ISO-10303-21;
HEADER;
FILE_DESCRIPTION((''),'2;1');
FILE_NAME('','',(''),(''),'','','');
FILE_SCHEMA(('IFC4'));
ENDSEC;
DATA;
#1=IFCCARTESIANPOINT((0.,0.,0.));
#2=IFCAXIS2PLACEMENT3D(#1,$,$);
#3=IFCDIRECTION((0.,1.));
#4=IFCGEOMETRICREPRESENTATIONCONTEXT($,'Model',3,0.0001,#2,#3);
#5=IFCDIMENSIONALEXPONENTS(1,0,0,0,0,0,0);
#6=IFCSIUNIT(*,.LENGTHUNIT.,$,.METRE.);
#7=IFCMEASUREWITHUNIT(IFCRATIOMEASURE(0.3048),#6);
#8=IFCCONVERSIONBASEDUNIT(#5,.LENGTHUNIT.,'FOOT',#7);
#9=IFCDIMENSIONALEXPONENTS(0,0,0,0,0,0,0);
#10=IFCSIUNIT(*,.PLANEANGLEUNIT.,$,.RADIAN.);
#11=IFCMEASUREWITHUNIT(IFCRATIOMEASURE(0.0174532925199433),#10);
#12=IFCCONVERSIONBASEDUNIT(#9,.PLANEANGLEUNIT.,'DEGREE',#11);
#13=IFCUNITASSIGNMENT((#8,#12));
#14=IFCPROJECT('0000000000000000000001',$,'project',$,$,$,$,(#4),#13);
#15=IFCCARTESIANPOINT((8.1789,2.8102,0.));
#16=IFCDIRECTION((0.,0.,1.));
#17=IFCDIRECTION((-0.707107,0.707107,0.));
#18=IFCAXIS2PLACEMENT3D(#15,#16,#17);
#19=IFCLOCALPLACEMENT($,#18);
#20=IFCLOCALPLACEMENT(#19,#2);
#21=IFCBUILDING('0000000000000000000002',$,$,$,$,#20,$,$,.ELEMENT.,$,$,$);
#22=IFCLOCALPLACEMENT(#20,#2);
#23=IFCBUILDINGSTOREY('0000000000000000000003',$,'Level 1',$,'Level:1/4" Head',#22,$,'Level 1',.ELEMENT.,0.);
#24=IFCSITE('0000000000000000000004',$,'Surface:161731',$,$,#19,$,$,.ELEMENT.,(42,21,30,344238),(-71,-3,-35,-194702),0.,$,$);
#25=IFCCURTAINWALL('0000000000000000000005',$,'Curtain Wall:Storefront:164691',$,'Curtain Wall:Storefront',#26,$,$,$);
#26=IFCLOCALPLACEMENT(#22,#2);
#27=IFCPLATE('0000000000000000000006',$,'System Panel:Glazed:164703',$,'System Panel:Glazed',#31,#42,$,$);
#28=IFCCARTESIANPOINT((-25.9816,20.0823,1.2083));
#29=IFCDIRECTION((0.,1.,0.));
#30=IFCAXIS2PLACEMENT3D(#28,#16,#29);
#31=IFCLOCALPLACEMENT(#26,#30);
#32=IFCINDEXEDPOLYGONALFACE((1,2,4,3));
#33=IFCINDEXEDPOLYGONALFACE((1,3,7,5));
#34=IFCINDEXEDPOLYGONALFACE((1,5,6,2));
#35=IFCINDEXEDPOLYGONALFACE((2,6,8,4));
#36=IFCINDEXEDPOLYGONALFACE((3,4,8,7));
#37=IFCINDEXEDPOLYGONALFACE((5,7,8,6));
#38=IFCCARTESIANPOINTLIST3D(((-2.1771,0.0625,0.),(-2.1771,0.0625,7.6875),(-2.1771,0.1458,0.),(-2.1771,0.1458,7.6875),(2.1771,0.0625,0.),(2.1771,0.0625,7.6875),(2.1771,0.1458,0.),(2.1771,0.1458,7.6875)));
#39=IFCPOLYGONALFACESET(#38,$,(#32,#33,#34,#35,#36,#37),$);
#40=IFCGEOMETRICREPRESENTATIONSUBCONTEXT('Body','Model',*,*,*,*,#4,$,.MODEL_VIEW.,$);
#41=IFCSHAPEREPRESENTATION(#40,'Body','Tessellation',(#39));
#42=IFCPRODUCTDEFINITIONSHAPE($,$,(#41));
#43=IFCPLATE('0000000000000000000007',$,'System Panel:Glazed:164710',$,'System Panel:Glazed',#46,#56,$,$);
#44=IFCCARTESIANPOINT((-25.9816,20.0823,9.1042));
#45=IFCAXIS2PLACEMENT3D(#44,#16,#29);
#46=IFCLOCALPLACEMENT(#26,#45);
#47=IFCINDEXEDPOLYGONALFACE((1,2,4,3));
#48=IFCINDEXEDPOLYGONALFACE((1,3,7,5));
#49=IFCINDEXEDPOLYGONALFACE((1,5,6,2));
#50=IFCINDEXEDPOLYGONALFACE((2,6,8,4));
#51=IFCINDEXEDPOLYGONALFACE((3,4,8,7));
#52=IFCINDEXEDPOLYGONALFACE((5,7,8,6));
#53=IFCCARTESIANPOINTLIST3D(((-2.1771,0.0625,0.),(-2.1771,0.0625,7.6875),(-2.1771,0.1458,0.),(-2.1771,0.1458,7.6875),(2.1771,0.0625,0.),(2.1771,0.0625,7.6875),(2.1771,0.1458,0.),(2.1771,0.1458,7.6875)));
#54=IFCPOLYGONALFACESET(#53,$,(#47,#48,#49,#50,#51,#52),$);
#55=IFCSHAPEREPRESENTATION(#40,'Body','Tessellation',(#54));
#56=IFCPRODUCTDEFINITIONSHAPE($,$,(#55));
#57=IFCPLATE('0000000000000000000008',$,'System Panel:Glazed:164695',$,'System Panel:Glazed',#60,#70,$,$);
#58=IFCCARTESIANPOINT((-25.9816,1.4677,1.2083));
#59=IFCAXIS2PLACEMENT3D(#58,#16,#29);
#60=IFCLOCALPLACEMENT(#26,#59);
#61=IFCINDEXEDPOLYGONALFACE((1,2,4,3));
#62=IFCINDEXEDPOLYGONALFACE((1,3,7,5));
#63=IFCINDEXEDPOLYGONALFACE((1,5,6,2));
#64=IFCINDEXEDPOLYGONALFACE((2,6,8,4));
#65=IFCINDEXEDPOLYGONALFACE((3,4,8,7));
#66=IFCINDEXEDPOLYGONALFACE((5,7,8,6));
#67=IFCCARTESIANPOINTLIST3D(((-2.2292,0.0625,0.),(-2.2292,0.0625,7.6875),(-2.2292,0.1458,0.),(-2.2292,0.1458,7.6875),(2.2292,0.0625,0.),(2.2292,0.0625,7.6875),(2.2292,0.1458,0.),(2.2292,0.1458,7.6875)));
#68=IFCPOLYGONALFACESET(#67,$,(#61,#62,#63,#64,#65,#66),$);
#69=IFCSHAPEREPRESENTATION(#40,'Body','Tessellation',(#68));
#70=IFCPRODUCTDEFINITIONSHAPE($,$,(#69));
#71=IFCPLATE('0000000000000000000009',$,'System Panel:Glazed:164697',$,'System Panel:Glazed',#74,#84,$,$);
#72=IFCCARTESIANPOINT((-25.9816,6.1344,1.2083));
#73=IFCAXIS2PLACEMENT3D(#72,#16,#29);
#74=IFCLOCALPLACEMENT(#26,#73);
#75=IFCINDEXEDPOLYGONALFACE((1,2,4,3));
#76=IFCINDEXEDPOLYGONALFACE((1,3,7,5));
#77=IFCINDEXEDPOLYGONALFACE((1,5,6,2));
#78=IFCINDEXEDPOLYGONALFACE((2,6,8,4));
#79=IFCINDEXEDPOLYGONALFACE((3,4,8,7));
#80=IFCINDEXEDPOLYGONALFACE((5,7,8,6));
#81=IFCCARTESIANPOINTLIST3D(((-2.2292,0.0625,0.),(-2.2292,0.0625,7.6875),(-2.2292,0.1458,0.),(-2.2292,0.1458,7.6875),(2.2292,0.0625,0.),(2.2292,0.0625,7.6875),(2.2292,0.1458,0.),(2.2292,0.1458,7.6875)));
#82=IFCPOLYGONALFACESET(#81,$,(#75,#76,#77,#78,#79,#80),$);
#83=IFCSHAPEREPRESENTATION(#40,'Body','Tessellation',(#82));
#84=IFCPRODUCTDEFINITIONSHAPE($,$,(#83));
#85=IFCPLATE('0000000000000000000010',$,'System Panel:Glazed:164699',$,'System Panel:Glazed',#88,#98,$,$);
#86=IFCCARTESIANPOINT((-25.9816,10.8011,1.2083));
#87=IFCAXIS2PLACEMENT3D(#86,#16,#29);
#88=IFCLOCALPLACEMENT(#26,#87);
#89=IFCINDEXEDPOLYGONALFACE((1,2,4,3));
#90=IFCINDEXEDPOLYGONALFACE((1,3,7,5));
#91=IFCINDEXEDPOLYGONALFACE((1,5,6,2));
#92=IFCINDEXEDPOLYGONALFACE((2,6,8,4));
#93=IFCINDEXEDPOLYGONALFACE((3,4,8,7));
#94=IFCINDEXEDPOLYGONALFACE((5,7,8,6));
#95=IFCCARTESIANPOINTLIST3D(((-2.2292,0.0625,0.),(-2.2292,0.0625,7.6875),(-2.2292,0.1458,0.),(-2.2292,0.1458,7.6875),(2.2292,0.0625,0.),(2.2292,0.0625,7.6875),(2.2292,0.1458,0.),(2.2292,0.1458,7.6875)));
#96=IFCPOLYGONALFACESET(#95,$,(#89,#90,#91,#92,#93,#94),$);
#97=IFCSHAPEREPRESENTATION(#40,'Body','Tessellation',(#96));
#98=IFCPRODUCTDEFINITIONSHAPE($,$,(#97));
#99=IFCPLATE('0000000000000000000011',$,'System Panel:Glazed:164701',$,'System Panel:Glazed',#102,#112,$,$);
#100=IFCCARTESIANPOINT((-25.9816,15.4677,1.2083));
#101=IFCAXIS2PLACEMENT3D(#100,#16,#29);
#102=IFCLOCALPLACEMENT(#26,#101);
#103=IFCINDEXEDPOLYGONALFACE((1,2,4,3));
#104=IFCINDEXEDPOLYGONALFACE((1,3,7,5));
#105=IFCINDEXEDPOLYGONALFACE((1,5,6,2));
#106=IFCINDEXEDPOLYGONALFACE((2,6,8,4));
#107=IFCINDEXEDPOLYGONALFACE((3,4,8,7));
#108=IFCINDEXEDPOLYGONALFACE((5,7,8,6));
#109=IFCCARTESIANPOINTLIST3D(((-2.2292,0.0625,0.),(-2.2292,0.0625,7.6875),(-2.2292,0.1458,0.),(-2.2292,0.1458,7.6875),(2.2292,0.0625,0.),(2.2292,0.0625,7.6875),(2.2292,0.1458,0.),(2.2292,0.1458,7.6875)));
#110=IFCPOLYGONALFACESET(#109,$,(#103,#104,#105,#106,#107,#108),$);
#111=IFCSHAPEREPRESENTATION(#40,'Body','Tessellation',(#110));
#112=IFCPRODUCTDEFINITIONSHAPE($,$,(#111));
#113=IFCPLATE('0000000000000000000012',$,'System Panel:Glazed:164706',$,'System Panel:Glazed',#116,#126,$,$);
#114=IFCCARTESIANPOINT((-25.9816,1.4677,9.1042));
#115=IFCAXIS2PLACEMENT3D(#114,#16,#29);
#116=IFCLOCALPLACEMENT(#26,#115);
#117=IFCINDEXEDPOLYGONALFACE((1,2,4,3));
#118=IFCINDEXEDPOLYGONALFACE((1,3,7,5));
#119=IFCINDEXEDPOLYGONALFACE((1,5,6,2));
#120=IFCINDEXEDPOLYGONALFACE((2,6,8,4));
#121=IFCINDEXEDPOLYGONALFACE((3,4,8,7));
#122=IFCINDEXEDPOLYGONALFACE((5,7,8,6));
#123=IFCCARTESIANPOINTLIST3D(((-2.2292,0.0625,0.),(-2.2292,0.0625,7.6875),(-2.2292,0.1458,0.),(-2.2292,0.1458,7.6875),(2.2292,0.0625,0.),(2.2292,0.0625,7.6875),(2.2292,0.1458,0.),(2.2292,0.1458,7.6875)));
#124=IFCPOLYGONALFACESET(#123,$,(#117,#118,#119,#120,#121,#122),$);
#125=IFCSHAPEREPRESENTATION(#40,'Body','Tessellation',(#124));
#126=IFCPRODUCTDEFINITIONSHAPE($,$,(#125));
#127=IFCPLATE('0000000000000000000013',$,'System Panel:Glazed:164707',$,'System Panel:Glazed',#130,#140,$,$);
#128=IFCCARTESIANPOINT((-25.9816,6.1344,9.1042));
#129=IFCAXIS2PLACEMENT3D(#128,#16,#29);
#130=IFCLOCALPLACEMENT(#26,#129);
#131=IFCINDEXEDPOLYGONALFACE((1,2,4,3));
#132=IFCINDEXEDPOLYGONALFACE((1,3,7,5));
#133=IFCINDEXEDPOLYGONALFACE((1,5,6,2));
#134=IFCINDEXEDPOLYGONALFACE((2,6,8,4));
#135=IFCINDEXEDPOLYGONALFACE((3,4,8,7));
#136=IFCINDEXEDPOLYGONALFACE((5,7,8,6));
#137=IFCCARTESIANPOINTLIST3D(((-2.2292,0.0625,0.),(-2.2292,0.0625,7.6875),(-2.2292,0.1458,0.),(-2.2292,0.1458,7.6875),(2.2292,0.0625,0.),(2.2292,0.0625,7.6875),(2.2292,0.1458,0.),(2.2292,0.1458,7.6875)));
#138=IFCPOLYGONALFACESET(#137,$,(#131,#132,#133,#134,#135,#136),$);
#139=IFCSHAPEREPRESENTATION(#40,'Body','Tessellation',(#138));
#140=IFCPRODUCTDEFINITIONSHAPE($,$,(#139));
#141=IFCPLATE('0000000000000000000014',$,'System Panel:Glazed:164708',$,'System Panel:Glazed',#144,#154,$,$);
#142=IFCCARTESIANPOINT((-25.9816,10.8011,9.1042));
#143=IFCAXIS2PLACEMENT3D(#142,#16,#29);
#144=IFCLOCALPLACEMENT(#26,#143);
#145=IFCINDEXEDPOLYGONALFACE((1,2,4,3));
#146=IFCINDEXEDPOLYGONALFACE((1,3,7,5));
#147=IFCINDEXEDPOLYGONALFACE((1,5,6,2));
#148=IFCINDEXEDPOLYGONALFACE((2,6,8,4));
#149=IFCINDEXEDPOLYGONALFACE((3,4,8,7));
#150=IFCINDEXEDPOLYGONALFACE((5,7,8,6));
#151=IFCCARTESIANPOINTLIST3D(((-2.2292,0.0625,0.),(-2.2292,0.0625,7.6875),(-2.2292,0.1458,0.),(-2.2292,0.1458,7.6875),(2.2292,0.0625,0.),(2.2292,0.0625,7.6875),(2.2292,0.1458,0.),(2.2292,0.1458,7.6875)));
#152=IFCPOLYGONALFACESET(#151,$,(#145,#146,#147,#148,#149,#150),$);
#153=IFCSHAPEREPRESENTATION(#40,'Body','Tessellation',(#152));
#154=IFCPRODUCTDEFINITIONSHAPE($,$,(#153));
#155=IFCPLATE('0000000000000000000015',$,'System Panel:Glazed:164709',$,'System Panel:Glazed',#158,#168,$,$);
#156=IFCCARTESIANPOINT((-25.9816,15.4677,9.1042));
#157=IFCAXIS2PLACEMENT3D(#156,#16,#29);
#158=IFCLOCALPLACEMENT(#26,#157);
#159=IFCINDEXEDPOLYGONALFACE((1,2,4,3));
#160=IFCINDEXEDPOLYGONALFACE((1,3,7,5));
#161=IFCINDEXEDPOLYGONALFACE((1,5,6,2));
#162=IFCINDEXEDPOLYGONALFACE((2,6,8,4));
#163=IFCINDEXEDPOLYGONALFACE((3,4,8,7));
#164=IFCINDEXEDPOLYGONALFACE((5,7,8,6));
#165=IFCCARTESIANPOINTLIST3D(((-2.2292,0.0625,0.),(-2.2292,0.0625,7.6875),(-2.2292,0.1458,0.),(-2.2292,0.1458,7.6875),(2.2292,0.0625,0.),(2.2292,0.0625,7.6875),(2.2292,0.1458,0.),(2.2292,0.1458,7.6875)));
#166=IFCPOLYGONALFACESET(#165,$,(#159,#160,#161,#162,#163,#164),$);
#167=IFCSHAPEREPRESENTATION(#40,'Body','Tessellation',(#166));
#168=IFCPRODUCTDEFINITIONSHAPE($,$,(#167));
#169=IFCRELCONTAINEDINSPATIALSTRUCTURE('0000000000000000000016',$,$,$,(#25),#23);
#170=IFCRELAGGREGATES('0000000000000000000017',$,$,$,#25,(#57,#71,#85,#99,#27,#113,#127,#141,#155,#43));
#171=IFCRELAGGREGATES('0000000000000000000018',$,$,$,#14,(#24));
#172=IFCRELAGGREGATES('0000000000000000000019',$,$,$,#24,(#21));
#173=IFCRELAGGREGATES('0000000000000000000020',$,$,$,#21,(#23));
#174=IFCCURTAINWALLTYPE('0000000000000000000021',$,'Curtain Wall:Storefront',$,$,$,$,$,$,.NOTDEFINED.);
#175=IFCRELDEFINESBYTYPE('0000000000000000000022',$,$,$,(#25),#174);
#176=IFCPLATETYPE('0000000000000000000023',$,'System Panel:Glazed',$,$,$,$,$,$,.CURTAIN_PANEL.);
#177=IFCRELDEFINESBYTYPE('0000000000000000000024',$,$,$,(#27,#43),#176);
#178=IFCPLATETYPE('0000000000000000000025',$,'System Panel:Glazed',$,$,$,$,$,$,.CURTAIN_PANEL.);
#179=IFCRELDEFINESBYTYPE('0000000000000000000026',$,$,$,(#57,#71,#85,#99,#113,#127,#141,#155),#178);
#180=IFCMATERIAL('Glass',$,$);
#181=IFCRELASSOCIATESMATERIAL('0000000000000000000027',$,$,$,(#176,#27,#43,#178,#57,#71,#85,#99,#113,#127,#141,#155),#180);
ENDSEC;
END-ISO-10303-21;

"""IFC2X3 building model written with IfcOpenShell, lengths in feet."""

from ifc_helpers import new_model, entity, si_unit, converted_unit, direction, frame, frame_2d, origin, place, context, subcontext, project, spatial, rectangle, extrude, source, transform, mapped, material, type_object, type_shapes, element, aggregate, save


model = new_model("IFC2X3")

# Units and contexts
model_context = context("Model", 3, precision=0.0001, world=origin(), true_north=direction((0.0, 1.0)))
body_context = subcontext(model_context, "Body", "Model", "MODEL_VIEW")
ifc_project = project(units=[converted_unit("LENGTHUNIT", "FOOT", entity("IfcRatioMeasure", 0.3048), si_unit("LENGTHUNIT", "METRE"), dimensions=[1, 0, 0, 0, 0, 0, 0]), converted_unit("PLANEANGLEUNIT", "DEGREE", entity("IfcRatioMeasure", 0.0174532925199433), si_unit("PLANEANGLEUNIT", "RADIAN"), dimensions=[0, 0, 0, 0, 0, 0, 0])], contexts=[model_context])

# Site, building, storey
site_placement = place(None, frame((8.1789, 2.8102, 0.0), z_axis=(0.0, 0.0, 1.0), x_axis=(-0.707107, 0.707107, 0.0)))
site = spatial("IfcSite", under=ifc_project, at=site_placement, Name="Surface:161731", CompositionType="ELEMENT", RefLatitude=(42, 21, 30, 344238), RefLongitude=(-71, -3, -35, -194702), RefElevation=0.0)
building_placement = place(site_placement, origin())
building = spatial("IfcBuilding", under=site, at=building_placement, CompositionType="ELEMENT")
storey_placement = place(building_placement, origin())
storey = spatial("IfcBuildingStorey", under=building, at=storey_placement, Name="Level 1", ObjectType="Level:1/4\" Head", LongName="Level 1", CompositionType="ELEMENT", Elevation=0.0)

# Curtain wall, plates
curtain_wall_type = type_object("IfcCurtainWallType", Name="Curtain Wall:Storefront", PredefinedType="NOTDEFINED")
curtain_wall_placement = place(storey_placement, origin())
curtain_wall = element("IfcCurtainWall", 1, at=curtain_wall_placement, inside=storey, type_object=curtain_wall_type, Name="Curtain Wall:Storefront:164691", ObjectType="Curtain Wall:Storefront")
ifc_material_1 = material(Name="Glass")
plate_type_1 = type_object("IfcPlateType", Name="System Panel:Glazed", PredefinedType="CURTAIN_PANEL", material=ifc_material_1)
shared_shape_1 = source(origin(), body_context, "Body", "SweptSolid", [
    extrude(rectangle(XDim=0.0833, YDim=4.3542, at=frame_2d((0.0, 0.0), x_axis=(1.0, 0.0))), frame((0.0, 0.1042, 0.0), z_axis=(0.0, 0.0, 1.0), x_axis=(0.0, 1.0, 0.0)), (0.0, 0.0, 1.0), 7.6875),
])
type_shapes(plate_type_1, [shared_shape_1])
plate_1_placement = place(curtain_wall_placement, frame((-25.9816, 20.0823, 1.2083), z_axis=(0.0, 0.0, 1.0), x_axis=(0.0, 1.0, 0.0)))
plate_1 = element("IfcPlate", 2, at=plate_1_placement, type_object=plate_type_1, material=ifc_material_1, Name="System Panel:Glazed:164703", ObjectType="System Panel:Glazed", context=body_context, shape_type="MappedRepresentation", body=[
    mapped(shared_shape_1, transform((0.0, 0.0, 0.0), scale=1.0)),
])
plate_2_placement = place(curtain_wall_placement, frame((-25.9816, 20.0823, 9.1042), z_axis=(0.0, 0.0, 1.0), x_axis=(0.0, 1.0, 0.0)))
plate_2 = element("IfcPlate", 3, at=plate_2_placement, type_object=plate_type_1, material=ifc_material_1, Name="System Panel:Glazed:164710", ObjectType="System Panel:Glazed", context=body_context, shape_type="MappedRepresentation", body=[
    mapped(shared_shape_1, transform((0.0, 0.0, 0.0), scale=1.0)),
])
plate_type_2 = type_object("IfcPlateType", Name="System Panel:Glazed", PredefinedType="CURTAIN_PANEL", material=ifc_material_1)
shared_shape_2 = source(origin(), body_context, "Body", "SweptSolid", [
    extrude(rectangle(XDim=0.0833, YDim=4.4583, at=frame_2d((0.0, 0.0), x_axis=(1.0, 0.0))), frame((0.0, 0.1042, 0.0), z_axis=(0.0, 0.0, 1.0), x_axis=(0.0, 1.0, 0.0)), (0.0, 0.0, 1.0), 7.6875),
])
type_shapes(plate_type_2, [shared_shape_2])
plate_3_placement = place(curtain_wall_placement, frame((-25.9816, 1.4677, 1.2083), z_axis=(0.0, 0.0, 1.0), x_axis=(0.0, 1.0, 0.0)))
plate_3 = element("IfcPlate", 4, at=plate_3_placement, type_object=plate_type_2, material=ifc_material_1, Name="System Panel:Glazed:164695", ObjectType="System Panel:Glazed", context=body_context, shape_type="MappedRepresentation", body=[
    mapped(shared_shape_2, transform((0.0, 0.0, 0.0), scale=1.0)),
])
plate_4_placement = place(curtain_wall_placement, frame((-25.9816, 6.1344, 1.2083), z_axis=(0.0, 0.0, 1.0), x_axis=(0.0, 1.0, 0.0)))
plate_4 = element("IfcPlate", 5, at=plate_4_placement, type_object=plate_type_2, material=ifc_material_1, Name="System Panel:Glazed:164697", ObjectType="System Panel:Glazed", context=body_context, shape_type="MappedRepresentation", body=[
    mapped(shared_shape_2, transform((0.0, 0.0, 0.0), scale=1.0)),
])
plate_5_placement = place(curtain_wall_placement, frame((-25.9816, 10.8011, 1.2083), z_axis=(0.0, 0.0, 1.0), x_axis=(0.0, 1.0, 0.0)))
plate_5 = element("IfcPlate", 6, at=plate_5_placement, type_object=plate_type_2, material=ifc_material_1, Name="System Panel:Glazed:164699", ObjectType="System Panel:Glazed", context=body_context, shape_type="MappedRepresentation", body=[
    mapped(shared_shape_2, transform((0.0, 0.0, 0.0), scale=1.0)),
])
plate_6_placement = place(curtain_wall_placement, frame((-25.9816, 15.4677, 1.2083), z_axis=(0.0, 0.0, 1.0), x_axis=(0.0, 1.0, 0.0)))
plate_6 = element("IfcPlate", 7, at=plate_6_placement, type_object=plate_type_2, material=ifc_material_1, Name="System Panel:Glazed:164701", ObjectType="System Panel:Glazed", context=body_context, shape_type="MappedRepresentation", body=[
    mapped(shared_shape_2, transform((0.0, 0.0, 0.0), scale=1.0)),
])
plate_7_placement = place(curtain_wall_placement, frame((-25.9816, 1.4677, 9.1042), z_axis=(0.0, 0.0, 1.0), x_axis=(0.0, 1.0, 0.0)))
plate_7 = element("IfcPlate", 8, at=plate_7_placement, type_object=plate_type_2, material=ifc_material_1, Name="System Panel:Glazed:164706", ObjectType="System Panel:Glazed", context=body_context, shape_type="MappedRepresentation", body=[
    mapped(shared_shape_2, transform((0.0, 0.0, 0.0), scale=1.0)),
])
plate_8_placement = place(curtain_wall_placement, frame((-25.9816, 6.1344, 9.1042), z_axis=(0.0, 0.0, 1.0), x_axis=(0.0, 1.0, 0.0)))
plate_8 = element("IfcPlate", 9, at=plate_8_placement, type_object=plate_type_2, material=ifc_material_1, Name="System Panel:Glazed:164707", ObjectType="System Panel:Glazed", context=body_context, shape_type="MappedRepresentation", body=[
    mapped(shared_shape_2, transform((0.0, 0.0, 0.0), scale=1.0)),
])
plate_9_placement = place(curtain_wall_placement, frame((-25.9816, 10.8011, 9.1042), z_axis=(0.0, 0.0, 1.0), x_axis=(0.0, 1.0, 0.0)))
plate_9 = element("IfcPlate", 10, at=plate_9_placement, type_object=plate_type_2, material=ifc_material_1, Name="System Panel:Glazed:164708", ObjectType="System Panel:Glazed", context=body_context, shape_type="MappedRepresentation", body=[
    mapped(shared_shape_2, transform((0.0, 0.0, 0.0), scale=1.0)),
])
plate_10_placement = place(curtain_wall_placement, frame((-25.9816, 15.4677, 9.1042), z_axis=(0.0, 0.0, 1.0), x_axis=(0.0, 1.0, 0.0)))
plate_10 = element("IfcPlate", 11, at=plate_10_placement, type_object=plate_type_2, material=ifc_material_1, Name="System Panel:Glazed:164709", ObjectType="System Panel:Glazed", context=body_context, shape_type="MappedRepresentation", body=[
    mapped(shared_shape_2, transform((0.0, 0.0, 0.0), scale=1.0)),
])
aggregate(curtain_wall, [plate_3, plate_4, plate_5, plate_6, plate_1, plate_7, plate_8, plate_9, plate_10, plate_2])

save(model, "model.ifc")
